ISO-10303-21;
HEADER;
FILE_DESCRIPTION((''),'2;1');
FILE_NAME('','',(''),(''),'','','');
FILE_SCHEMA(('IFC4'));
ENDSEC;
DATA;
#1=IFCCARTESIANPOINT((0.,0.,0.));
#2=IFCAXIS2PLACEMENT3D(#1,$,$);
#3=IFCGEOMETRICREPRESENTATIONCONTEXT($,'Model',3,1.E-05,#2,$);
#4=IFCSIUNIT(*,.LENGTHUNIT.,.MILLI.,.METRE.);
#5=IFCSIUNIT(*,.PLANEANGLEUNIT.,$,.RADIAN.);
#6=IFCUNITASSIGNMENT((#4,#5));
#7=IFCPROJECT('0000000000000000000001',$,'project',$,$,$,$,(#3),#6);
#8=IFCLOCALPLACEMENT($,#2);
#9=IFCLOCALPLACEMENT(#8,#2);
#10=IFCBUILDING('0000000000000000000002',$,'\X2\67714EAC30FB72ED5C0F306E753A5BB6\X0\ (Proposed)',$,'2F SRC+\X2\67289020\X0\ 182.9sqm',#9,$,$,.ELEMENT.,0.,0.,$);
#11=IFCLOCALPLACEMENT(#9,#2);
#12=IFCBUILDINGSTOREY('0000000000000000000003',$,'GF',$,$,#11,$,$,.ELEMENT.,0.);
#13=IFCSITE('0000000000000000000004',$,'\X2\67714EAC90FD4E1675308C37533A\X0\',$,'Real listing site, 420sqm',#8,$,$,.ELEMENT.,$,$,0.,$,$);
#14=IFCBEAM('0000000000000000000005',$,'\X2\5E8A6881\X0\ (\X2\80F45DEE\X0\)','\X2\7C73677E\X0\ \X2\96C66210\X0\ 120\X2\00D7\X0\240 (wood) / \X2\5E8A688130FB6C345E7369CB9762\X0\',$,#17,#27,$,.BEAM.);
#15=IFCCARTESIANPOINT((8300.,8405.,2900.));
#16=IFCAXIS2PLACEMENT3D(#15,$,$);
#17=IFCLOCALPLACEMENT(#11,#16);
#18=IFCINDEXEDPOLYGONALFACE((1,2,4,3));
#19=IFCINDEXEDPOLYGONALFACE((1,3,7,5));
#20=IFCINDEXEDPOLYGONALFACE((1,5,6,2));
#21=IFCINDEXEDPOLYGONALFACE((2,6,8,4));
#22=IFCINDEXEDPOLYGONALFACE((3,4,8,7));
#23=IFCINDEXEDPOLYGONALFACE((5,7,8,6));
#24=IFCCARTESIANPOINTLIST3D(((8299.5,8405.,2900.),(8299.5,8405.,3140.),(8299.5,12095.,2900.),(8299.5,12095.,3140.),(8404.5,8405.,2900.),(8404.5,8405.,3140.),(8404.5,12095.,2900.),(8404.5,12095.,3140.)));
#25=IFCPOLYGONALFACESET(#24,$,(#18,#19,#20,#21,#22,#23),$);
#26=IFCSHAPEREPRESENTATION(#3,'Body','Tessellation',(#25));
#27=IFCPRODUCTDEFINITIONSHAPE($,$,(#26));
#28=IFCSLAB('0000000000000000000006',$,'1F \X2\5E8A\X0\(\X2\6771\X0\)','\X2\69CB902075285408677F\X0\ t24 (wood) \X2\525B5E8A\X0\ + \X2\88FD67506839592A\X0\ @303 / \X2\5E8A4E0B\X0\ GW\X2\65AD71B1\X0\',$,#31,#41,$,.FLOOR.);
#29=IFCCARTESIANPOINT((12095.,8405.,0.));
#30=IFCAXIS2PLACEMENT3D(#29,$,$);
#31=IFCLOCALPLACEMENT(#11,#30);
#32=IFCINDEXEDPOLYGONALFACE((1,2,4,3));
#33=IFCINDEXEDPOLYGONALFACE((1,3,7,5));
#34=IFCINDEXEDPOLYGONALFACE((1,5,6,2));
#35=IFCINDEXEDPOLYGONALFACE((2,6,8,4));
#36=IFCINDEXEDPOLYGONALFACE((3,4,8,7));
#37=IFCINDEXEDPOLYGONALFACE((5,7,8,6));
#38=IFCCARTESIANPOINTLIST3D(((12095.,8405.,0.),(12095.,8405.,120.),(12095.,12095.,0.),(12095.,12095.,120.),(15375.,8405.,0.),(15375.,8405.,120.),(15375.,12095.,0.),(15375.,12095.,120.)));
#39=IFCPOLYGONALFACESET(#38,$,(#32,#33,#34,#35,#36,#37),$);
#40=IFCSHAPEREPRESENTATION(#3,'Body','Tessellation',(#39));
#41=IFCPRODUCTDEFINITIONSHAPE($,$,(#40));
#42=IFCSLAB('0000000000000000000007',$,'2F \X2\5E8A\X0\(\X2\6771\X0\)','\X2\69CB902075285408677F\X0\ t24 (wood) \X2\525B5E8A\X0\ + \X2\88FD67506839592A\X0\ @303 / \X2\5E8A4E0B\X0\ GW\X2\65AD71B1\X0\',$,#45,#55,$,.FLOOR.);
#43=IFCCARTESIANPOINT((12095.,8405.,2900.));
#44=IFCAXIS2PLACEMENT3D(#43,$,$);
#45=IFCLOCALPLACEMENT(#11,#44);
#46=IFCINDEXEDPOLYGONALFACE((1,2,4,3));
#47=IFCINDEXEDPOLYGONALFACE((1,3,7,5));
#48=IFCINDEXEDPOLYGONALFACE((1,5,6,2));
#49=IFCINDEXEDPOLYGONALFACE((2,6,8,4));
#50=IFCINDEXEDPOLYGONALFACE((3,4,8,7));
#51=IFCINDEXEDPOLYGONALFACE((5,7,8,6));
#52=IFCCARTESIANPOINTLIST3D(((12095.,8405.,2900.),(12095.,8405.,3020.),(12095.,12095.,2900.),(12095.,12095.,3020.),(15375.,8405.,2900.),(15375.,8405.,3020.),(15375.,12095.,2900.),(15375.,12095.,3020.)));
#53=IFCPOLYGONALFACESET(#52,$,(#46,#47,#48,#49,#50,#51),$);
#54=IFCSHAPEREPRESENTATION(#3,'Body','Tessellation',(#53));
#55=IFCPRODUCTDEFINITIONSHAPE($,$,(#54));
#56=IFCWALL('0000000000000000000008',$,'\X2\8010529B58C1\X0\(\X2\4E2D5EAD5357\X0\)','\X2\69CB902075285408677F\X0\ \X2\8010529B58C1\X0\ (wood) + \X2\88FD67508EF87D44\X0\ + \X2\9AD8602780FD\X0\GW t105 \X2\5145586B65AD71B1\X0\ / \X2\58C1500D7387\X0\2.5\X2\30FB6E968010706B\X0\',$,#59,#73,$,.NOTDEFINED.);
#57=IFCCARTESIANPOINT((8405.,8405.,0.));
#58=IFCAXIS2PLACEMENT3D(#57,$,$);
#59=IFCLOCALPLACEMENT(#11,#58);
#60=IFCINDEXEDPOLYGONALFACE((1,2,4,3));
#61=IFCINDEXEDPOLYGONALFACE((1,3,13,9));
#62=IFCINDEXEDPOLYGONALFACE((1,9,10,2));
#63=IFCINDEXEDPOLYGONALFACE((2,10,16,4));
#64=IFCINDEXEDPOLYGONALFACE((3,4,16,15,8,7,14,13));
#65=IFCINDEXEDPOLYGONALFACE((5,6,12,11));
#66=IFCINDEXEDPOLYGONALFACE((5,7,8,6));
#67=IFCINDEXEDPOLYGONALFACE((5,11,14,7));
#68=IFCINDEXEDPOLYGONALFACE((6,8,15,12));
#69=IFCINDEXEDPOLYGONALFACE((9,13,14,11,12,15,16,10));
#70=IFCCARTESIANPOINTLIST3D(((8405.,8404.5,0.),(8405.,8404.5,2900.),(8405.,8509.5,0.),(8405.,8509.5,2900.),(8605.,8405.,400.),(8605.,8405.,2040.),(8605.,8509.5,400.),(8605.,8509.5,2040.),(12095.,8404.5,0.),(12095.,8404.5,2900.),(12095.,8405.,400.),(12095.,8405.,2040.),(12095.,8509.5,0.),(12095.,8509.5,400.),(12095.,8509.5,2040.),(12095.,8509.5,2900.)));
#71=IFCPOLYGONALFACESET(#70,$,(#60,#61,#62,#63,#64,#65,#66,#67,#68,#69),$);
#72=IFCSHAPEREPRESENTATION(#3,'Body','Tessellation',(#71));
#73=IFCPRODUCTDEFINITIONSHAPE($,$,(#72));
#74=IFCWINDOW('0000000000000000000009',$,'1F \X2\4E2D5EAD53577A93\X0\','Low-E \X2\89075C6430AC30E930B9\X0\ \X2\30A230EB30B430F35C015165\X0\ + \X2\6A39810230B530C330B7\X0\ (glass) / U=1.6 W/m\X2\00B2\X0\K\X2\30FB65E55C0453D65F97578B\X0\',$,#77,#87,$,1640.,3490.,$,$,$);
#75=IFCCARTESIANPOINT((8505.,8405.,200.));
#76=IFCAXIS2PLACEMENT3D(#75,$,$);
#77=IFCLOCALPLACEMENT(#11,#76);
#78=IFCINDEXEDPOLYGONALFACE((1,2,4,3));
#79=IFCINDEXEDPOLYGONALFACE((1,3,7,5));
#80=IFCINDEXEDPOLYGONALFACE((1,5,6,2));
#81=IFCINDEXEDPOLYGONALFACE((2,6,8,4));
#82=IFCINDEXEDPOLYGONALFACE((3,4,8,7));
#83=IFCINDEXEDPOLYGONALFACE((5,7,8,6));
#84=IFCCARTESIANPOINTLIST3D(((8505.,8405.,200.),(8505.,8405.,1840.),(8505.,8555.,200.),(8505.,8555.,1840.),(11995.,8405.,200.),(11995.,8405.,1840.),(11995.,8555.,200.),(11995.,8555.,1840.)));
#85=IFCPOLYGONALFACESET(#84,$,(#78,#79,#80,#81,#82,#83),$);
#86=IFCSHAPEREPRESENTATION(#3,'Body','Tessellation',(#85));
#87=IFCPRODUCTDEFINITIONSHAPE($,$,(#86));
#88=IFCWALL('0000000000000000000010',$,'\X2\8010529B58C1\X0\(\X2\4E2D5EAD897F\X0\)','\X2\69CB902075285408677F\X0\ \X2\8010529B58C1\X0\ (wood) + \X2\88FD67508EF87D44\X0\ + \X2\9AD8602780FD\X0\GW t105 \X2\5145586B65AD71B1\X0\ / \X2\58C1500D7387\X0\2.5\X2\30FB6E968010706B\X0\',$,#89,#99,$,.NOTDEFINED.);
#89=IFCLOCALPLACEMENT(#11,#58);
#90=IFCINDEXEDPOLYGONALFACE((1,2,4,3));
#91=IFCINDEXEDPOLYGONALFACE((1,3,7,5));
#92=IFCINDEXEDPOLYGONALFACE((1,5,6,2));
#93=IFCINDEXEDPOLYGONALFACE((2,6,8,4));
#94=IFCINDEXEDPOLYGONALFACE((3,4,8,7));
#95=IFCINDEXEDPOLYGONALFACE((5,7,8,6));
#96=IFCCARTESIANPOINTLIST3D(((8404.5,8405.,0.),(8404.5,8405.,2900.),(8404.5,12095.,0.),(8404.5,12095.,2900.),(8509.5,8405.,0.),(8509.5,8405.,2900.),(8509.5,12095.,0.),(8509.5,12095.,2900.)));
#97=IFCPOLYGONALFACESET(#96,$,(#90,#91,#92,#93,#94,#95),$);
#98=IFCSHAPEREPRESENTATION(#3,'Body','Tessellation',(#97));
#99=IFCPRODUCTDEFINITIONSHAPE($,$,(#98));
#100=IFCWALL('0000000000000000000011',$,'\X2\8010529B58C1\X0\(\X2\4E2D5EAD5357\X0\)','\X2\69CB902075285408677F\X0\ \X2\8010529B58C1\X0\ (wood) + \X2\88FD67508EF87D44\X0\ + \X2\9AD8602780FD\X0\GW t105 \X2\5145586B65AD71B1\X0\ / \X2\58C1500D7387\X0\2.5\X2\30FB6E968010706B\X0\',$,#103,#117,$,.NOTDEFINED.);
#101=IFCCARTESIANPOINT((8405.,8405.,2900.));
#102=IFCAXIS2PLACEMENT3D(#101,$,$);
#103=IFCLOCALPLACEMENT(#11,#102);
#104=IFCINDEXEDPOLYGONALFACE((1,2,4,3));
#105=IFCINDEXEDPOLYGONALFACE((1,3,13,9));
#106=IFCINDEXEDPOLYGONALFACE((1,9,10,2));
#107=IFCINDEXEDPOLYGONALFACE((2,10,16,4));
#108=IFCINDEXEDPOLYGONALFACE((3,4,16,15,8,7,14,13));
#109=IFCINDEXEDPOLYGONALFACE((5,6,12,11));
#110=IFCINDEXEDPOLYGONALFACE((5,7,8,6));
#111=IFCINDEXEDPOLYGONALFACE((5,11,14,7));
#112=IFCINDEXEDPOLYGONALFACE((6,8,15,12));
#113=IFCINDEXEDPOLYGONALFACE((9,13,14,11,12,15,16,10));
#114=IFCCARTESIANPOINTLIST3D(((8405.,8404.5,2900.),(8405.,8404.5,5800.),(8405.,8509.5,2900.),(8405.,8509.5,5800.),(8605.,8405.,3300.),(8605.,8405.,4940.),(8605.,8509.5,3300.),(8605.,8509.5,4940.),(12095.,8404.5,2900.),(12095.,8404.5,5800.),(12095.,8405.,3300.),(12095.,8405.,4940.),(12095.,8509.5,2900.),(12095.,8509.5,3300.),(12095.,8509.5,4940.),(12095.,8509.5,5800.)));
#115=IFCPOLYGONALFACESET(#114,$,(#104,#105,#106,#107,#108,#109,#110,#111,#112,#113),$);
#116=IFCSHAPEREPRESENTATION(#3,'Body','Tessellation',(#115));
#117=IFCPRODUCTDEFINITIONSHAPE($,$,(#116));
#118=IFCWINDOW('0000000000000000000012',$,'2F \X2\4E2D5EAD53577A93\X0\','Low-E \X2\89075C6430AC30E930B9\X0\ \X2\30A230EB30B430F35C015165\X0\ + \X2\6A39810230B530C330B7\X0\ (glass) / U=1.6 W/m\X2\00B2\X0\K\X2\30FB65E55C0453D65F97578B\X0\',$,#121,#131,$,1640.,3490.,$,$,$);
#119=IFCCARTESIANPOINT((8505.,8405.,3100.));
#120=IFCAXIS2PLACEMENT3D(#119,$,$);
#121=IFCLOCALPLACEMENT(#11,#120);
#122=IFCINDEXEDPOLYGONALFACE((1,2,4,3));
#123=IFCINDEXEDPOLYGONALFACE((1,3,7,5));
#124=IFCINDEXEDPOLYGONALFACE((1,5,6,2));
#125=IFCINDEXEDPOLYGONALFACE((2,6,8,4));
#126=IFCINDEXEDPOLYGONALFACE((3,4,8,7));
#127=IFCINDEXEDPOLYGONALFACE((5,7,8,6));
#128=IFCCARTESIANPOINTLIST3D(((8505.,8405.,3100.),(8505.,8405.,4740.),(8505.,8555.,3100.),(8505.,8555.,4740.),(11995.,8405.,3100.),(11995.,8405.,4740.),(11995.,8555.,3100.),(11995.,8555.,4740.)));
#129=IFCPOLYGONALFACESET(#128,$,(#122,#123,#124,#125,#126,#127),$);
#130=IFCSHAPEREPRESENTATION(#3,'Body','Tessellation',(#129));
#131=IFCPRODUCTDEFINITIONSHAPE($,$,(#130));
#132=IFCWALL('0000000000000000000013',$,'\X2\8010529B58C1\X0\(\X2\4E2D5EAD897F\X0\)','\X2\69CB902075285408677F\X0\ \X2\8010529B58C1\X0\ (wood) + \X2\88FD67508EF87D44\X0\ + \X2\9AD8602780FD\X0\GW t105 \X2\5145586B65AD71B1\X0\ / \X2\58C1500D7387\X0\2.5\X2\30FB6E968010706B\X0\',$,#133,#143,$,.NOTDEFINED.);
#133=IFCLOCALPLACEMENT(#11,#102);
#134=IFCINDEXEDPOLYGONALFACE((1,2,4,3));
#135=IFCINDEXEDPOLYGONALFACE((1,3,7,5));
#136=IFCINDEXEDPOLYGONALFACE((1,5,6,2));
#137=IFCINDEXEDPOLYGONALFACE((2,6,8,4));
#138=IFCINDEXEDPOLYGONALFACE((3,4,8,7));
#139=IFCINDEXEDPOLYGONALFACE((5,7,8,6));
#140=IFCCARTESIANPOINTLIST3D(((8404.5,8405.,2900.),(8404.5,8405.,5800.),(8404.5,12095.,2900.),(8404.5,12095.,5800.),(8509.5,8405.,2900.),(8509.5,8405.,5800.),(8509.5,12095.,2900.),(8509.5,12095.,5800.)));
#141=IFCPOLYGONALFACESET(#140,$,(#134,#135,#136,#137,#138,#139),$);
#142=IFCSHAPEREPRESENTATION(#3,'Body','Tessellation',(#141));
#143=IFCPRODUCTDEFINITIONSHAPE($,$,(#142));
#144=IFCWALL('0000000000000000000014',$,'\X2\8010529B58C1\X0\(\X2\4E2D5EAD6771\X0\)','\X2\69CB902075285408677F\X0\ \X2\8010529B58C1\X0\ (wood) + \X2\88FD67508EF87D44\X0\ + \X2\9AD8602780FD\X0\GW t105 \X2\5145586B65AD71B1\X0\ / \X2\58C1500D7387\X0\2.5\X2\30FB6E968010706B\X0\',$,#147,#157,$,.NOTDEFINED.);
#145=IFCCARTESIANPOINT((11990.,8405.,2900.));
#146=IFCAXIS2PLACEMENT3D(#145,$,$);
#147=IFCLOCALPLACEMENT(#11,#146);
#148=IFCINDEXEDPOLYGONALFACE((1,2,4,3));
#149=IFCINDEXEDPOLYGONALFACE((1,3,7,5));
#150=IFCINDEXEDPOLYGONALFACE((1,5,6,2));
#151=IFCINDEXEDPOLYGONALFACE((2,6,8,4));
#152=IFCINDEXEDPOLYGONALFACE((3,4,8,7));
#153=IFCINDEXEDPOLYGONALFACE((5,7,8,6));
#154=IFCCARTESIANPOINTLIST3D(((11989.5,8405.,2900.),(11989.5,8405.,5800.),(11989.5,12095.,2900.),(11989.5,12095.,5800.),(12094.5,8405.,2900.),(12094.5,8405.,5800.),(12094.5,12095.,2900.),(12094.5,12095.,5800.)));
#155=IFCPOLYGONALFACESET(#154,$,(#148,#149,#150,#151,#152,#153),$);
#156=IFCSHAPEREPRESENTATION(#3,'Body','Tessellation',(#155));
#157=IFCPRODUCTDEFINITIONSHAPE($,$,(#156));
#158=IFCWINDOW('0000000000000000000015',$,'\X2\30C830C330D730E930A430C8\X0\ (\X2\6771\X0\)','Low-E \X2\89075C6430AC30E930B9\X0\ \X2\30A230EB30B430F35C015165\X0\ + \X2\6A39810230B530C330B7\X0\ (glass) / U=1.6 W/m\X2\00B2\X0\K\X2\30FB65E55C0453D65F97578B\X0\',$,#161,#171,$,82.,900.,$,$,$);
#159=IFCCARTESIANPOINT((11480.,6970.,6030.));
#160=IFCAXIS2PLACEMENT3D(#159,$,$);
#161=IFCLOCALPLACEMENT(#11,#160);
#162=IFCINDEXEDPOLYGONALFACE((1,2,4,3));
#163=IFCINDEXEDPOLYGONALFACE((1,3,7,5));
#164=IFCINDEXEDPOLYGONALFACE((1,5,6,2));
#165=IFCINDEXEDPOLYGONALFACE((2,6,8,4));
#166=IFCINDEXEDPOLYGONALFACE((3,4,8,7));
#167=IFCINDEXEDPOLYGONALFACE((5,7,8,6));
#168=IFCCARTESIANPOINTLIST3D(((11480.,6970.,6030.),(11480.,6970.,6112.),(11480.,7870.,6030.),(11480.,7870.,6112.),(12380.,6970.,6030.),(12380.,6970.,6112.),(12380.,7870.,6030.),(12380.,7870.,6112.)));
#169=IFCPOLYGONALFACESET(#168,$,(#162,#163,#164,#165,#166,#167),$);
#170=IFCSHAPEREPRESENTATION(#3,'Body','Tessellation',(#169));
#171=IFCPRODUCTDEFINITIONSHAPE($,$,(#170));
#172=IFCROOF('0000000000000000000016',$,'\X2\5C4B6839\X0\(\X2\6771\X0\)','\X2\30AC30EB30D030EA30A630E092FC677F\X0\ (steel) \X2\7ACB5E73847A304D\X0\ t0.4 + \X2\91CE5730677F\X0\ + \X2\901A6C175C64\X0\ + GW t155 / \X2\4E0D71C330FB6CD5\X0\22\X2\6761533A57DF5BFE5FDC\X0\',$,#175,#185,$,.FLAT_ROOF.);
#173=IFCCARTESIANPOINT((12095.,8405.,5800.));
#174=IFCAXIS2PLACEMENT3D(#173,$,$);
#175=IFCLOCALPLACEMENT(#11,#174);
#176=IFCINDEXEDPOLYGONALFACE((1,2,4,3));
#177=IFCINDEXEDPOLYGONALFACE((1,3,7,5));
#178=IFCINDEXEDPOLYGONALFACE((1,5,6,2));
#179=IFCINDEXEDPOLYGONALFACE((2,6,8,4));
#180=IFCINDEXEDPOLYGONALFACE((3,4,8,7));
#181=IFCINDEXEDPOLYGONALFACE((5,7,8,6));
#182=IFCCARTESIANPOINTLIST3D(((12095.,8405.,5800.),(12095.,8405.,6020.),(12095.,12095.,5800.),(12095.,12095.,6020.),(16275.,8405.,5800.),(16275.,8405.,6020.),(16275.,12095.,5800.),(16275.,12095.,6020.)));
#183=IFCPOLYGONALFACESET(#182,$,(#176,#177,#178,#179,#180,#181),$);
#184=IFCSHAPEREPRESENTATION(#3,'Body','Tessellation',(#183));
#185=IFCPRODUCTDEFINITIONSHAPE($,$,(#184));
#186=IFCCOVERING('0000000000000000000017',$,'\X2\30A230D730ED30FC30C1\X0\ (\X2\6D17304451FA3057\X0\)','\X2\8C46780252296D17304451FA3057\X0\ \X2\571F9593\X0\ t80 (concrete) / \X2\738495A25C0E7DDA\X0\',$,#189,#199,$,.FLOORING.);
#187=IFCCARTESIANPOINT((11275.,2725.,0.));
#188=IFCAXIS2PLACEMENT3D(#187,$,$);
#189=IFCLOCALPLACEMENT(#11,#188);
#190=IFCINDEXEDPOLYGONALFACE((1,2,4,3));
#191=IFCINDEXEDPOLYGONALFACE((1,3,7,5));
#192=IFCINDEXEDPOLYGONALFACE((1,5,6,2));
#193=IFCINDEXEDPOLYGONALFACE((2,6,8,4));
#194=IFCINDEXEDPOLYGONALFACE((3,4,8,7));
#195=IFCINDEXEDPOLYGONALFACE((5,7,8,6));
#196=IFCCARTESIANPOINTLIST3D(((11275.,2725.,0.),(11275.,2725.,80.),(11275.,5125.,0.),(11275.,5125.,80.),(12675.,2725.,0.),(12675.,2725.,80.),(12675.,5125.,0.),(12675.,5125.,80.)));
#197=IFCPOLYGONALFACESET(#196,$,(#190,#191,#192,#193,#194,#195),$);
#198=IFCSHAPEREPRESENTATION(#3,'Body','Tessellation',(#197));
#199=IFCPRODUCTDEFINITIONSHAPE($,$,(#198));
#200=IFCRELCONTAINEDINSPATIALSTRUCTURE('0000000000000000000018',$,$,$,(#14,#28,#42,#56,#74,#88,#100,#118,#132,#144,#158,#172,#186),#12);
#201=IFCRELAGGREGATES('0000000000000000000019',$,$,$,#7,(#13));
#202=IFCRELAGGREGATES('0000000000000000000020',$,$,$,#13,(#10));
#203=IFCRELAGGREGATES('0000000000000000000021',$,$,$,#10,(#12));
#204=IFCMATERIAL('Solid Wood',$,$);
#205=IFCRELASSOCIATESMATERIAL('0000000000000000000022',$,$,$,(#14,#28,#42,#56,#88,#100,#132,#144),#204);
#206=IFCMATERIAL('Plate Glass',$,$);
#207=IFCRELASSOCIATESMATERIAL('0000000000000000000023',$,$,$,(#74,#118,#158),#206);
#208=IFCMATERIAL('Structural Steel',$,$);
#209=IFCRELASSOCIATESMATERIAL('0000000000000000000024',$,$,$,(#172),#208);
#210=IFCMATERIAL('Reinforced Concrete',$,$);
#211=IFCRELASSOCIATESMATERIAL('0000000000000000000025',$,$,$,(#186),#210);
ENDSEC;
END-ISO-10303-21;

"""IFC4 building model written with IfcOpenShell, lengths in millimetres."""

from ifc_helpers import new_model, si_unit, frame, frame_2d, origin, place, context, project, spatial, rectangle, extrude, material, element, fill, save


model = new_model("IFC4")

# Units and contexts
model_context = context("Model", 3, precision=1e-05, world=origin())
ifc_project = project(units=[si_unit("LENGTHUNIT", "METRE", prefix="MILLI"), si_unit("PLANEANGLEUNIT", "RADIAN")], contexts=[model_context])

# Site, building, storey
site_placement = place(None, origin())
site = spatial("IfcSite", under=ifc_project, at=site_placement, Name="東京都世田谷区", ObjectType="Real listing site, 420sqm", CompositionType="ELEMENT", RefElevation=0.0)
building_placement = place(site_placement, origin())
building = spatial("IfcBuilding", under=site, at=building_placement, Name="東京・狭小の町家 (Proposed)", ObjectType="2F SRC+木造 182.9sqm", CompositionType="ELEMENT", ElevationOfRefHeight=0.0, ElevationOfTerrain=0.0)
storey_placement = place(building_placement, origin())
storey = spatial("IfcBuildingStorey", under=building, at=storey_placement, Name="GF", CompositionType="ELEMENT", Elevation=0.0)

# Shared definitions
ifc_material_1 = material(Name="Solid Wood")

# Beam
beam_placement = place(storey_placement, frame((8300.0, 8405.0, 2900.0)))
element("IfcBeam", 1, at=beam_placement, inside=storey, material=ifc_material_1, Name="床梁 (胴差)", Description="米松 集成 120×240 (wood) / 床梁・水平構面", PredefinedType="BEAM", context=model_context, shape_type="SweptSolid", body=[
    extrude(rectangle(XDim=105.0, YDim=3690.0, at=frame_2d((52.0, 1845.0))), frame((8300.0, 8405.0, 2900.0)), (0.0, 0.0, 1.0), 240.0),
])

# Slabs
slab_1_placement = place(storey_placement, frame((12095.0, 8405.0, 0.0)))
element("IfcSlab", 2, at=slab_1_placement, inside=storey, material=ifc_material_1, Name="1F 床(東)", Description="構造用合板 t24 (wood) 剛床 + 製材根太 @303 / 床下 GW断熱", PredefinedType="FLOOR", context=model_context, shape_type="SweptSolid", body=[
    extrude(rectangle(XDim=3280.0, YDim=3690.0, at=frame_2d((1640.0, 1845.0))), frame((12095.0, 8405.0, 0.0)), (0.0, 0.0, 1.0), 120.0),
])
slab_2_placement = place(storey_placement, frame((12095.0, 8405.0, 2900.0)))
element("IfcSlab", 3, at=slab_2_placement, inside=storey, material=ifc_material_1, Name="2F 床(東)", Description="構造用合板 t24 (wood) 剛床 + 製材根太 @303 / 床下 GW断熱", PredefinedType="FLOOR", context=model_context, shape_type="SweptSolid", body=[
    extrude(rectangle(XDim=3280.0, YDim=3690.0, at=frame_2d((1640.0, 1845.0))), frame((12095.0, 8405.0, 2900.0)), (0.0, 0.0, 1.0), 120.0),
])

# Wall, opening, window
wall_1_placement = place(storey_placement, frame((8405.0, 8405.0, 0.0)))
wall_1 = element("IfcWall", 4, at=wall_1_placement, inside=storey, material=ifc_material_1, Name="耐力壁(中庭南)", Description="構造用合板 耐力壁 (wood) + 製材軸組 + 高性能GW t105 充填断熱 / 壁倍率2.5・準耐火", PredefinedType="NOTDEFINED", context=model_context, shape_type="SweptSolid", body=[
    extrude(rectangle(XDim=3690.0, YDim=105.0, at=frame_2d((1845.0, 52.0))), frame((8405.0, 8405.0, 0.0)), (0.0, 0.0, 1.0), 2900.0),
])
opening_1_placement = place(storey_placement, frame((8505.0, 8405.0, 200.0)))
opening_1 = element("IfcOpeningElement", 5, at=opening_1_placement, cuts=wall_1, PredefinedType="NOTDEFINED", context=model_context, shape_type="SweptSolid", body=[
    extrude(rectangle(XDim=3490.0, YDim=150.0, at=frame_2d((1745.0, 75.0))), frame((8505.0, 8405.0, 200.0)), (0.0, 0.0, 1.0), 1640.0),
])
ifc_material_2 = material(Name="Plate Glass")
window_1_placement = place(storey_placement, frame((8505.0, 8405.0, 200.0)))
window_1 = element("IfcWindow", 6, at=window_1_placement, inside=storey, material=ifc_material_2, Name="1F 中庭南窓", Description="Low-E 複層ガラス アルゴン封入 + 樹脂サッシ (glass) / U=1.6 W/m²K・日射取得型", OverallHeight=1640.0, OverallWidth=3490.0, context=model_context, shape_type="SweptSolid", body=[
    extrude(rectangle(XDim=3490.0, YDim=150.0, at=frame_2d((1745.0, 75.0))), frame((8505.0, 8405.0, 200.0)), (0.0, 0.0, 1.0), 1640.0),
])
fill(opening_1, window_1)

# Wall
wall_2_placement = place(storey_placement, frame((8405.0, 8405.0, 0.0)))
element("IfcWall", 7, at=wall_2_placement, inside=storey, material=ifc_material_1, Name="耐力壁(中庭西)", Description="構造用合板 耐力壁 (wood) + 製材軸組 + 高性能GW t105 充填断熱 / 壁倍率2.5・準耐火", PredefinedType="NOTDEFINED", context=model_context, shape_type="SweptSolid", body=[
    extrude(rectangle(XDim=105.0, YDim=3690.0, at=frame_2d((52.0, 1845.0))), frame((8405.0, 8405.0, 0.0)), (0.0, 0.0, 1.0), 2900.0),
])

# Wall, opening, window
wall_3_placement = place(storey_placement, frame((8405.0, 8405.0, 2900.0)))
wall_3 = element("IfcWall", 8, at=wall_3_placement, inside=storey, material=ifc_material_1, Name="耐力壁(中庭南)", Description="構造用合板 耐力壁 (wood) + 製材軸組 + 高性能GW t105 充填断熱 / 壁倍率2.5・準耐火", PredefinedType="NOTDEFINED", context=model_context, shape_type="SweptSolid", body=[
    extrude(rectangle(XDim=3690.0, YDim=105.0, at=frame_2d((1845.0, 52.0))), frame((8405.0, 8405.0, 2900.0)), (0.0, 0.0, 1.0), 2900.0),
])
opening_2_placement = place(storey_placement, frame((8505.0, 8405.0, 3100.0)))
opening_2 = element("IfcOpeningElement", 9, at=opening_2_placement, cuts=wall_3, PredefinedType="NOTDEFINED", context=model_context, shape_type="SweptSolid", body=[
    extrude(rectangle(XDim=3490.0, YDim=150.0, at=frame_2d((1745.0, 75.0))), frame((8505.0, 8405.0, 3100.0)), (0.0, 0.0, 1.0), 1640.0),
])
window_2_placement = place(storey_placement, frame((8505.0, 8405.0, 3100.0)))
window_2 = element("IfcWindow", 10, at=window_2_placement, inside=storey, material=ifc_material_2, Name="2F 中庭南窓", Description="Low-E 複層ガラス アルゴン封入 + 樹脂サッシ (glass) / U=1.6 W/m²K・日射取得型", OverallHeight=1640.0, OverallWidth=3490.0, context=model_context, shape_type="SweptSolid", body=[
    extrude(rectangle(XDim=3490.0, YDim=150.0, at=frame_2d((1745.0, 75.0))), frame((8505.0, 8405.0, 3100.0)), (0.0, 0.0, 1.0), 1640.0),
])
fill(opening_2, window_2)

# Walls
wall_4_placement = place(storey_placement, frame((8405.0, 8405.0, 2900.0)))
element("IfcWall", 11, at=wall_4_placement, inside=storey, material=ifc_material_1, Name="耐力壁(中庭西)", Description="構造用合板 耐力壁 (wood) + 製材軸組 + 高性能GW t105 充填断熱 / 壁倍率2.5・準耐火", PredefinedType="NOTDEFINED", context=model_context, shape_type="SweptSolid", body=[
    extrude(rectangle(XDim=105.0, YDim=3690.0, at=frame_2d((52.0, 1845.0))), frame((8405.0, 8405.0, 2900.0)), (0.0, 0.0, 1.0), 2900.0),
])
wall_5_placement = place(storey_placement, frame((11990.0, 8405.0, 2900.0)))
element("IfcWall", 12, at=wall_5_placement, inside=storey, material=ifc_material_1, Name="耐力壁(中庭東)", Description="構造用合板 耐力壁 (wood) + 製材軸組 + 高性能GW t105 充填断熱 / 壁倍率2.5・準耐火", PredefinedType="NOTDEFINED", context=model_context, shape_type="SweptSolid", body=[
    extrude(rectangle(XDim=105.0, YDim=3690.0, at=frame_2d((52.0, 1845.0))), frame((11990.0, 8405.0, 2900.0)), (0.0, 0.0, 1.0), 2900.0),
])

# Window
window_3_placement = place(storey_placement, frame((11480.0, 6970.0, 6030.0)))
element("IfcWindow", 13, at=window_3_placement, inside=storey, material=ifc_material_2, Name="トップライト (東)", Description="Low-E 複層ガラス アルゴン封入 + 樹脂サッシ (glass) / U=1.6 W/m²K・日射取得型", OverallHeight=82.0, OverallWidth=900.0, context=model_context, shape_type="SweptSolid", body=[
    extrude(rectangle(XDim=900.0, YDim=900.0, at=frame_2d((450.0, 450.0))), frame((11480.0, 6970.0, 6030.0)), (0.0, 0.0, 1.0), 82.0),
])

# Roof
ifc_material_3 = material(Name="Structural Steel")
roof_placement = place(storey_placement, frame((12095.0, 8405.0, 5800.0)))
element("IfcRoof", 14, at=roof_placement, inside=storey, material=ifc_material_3, Name="屋根(東)", Description="ガルバリウム鋼板 (steel) 立平葺き t0.4 + 野地板 + 通気層 + GW t155 / 不燃・法22条区域対応", PredefinedType="FLAT_ROOF", context=model_context, shape_type="SweptSolid", body=[
    extrude(rectangle(XDim=4180.0, YDim=3690.0, at=frame_2d((2090.0, 1845.0))), frame((12095.0, 8405.0, 5800.0)), (0.0, 0.0, 1.0), 220.0),
])

# Covering
ifc_material_4 = material(Name="Reinforced Concrete")
covering_placement = place(storey_placement, frame((11275.0, 2725.0, 0.0)))
element("IfcCovering", 15, at=covering_placement, inside=storey, material=ifc_material_4, Name="アプローチ (洗い出し)", Description="豆砂利洗い出し 土間 t80 (concrete) / 玄関導線", PredefinedType="FLOORING", context=model_context, shape_type="SweptSolid", body=[
    extrude(rectangle(XDim=1400.0, YDim=2400.0, at=frame_2d((700.0, 1200.0))), frame((11275.0, 2725.0, 0.0)), (0.0, 0.0, 1.0), 80.0),
])

save(model, "model.ifc")
